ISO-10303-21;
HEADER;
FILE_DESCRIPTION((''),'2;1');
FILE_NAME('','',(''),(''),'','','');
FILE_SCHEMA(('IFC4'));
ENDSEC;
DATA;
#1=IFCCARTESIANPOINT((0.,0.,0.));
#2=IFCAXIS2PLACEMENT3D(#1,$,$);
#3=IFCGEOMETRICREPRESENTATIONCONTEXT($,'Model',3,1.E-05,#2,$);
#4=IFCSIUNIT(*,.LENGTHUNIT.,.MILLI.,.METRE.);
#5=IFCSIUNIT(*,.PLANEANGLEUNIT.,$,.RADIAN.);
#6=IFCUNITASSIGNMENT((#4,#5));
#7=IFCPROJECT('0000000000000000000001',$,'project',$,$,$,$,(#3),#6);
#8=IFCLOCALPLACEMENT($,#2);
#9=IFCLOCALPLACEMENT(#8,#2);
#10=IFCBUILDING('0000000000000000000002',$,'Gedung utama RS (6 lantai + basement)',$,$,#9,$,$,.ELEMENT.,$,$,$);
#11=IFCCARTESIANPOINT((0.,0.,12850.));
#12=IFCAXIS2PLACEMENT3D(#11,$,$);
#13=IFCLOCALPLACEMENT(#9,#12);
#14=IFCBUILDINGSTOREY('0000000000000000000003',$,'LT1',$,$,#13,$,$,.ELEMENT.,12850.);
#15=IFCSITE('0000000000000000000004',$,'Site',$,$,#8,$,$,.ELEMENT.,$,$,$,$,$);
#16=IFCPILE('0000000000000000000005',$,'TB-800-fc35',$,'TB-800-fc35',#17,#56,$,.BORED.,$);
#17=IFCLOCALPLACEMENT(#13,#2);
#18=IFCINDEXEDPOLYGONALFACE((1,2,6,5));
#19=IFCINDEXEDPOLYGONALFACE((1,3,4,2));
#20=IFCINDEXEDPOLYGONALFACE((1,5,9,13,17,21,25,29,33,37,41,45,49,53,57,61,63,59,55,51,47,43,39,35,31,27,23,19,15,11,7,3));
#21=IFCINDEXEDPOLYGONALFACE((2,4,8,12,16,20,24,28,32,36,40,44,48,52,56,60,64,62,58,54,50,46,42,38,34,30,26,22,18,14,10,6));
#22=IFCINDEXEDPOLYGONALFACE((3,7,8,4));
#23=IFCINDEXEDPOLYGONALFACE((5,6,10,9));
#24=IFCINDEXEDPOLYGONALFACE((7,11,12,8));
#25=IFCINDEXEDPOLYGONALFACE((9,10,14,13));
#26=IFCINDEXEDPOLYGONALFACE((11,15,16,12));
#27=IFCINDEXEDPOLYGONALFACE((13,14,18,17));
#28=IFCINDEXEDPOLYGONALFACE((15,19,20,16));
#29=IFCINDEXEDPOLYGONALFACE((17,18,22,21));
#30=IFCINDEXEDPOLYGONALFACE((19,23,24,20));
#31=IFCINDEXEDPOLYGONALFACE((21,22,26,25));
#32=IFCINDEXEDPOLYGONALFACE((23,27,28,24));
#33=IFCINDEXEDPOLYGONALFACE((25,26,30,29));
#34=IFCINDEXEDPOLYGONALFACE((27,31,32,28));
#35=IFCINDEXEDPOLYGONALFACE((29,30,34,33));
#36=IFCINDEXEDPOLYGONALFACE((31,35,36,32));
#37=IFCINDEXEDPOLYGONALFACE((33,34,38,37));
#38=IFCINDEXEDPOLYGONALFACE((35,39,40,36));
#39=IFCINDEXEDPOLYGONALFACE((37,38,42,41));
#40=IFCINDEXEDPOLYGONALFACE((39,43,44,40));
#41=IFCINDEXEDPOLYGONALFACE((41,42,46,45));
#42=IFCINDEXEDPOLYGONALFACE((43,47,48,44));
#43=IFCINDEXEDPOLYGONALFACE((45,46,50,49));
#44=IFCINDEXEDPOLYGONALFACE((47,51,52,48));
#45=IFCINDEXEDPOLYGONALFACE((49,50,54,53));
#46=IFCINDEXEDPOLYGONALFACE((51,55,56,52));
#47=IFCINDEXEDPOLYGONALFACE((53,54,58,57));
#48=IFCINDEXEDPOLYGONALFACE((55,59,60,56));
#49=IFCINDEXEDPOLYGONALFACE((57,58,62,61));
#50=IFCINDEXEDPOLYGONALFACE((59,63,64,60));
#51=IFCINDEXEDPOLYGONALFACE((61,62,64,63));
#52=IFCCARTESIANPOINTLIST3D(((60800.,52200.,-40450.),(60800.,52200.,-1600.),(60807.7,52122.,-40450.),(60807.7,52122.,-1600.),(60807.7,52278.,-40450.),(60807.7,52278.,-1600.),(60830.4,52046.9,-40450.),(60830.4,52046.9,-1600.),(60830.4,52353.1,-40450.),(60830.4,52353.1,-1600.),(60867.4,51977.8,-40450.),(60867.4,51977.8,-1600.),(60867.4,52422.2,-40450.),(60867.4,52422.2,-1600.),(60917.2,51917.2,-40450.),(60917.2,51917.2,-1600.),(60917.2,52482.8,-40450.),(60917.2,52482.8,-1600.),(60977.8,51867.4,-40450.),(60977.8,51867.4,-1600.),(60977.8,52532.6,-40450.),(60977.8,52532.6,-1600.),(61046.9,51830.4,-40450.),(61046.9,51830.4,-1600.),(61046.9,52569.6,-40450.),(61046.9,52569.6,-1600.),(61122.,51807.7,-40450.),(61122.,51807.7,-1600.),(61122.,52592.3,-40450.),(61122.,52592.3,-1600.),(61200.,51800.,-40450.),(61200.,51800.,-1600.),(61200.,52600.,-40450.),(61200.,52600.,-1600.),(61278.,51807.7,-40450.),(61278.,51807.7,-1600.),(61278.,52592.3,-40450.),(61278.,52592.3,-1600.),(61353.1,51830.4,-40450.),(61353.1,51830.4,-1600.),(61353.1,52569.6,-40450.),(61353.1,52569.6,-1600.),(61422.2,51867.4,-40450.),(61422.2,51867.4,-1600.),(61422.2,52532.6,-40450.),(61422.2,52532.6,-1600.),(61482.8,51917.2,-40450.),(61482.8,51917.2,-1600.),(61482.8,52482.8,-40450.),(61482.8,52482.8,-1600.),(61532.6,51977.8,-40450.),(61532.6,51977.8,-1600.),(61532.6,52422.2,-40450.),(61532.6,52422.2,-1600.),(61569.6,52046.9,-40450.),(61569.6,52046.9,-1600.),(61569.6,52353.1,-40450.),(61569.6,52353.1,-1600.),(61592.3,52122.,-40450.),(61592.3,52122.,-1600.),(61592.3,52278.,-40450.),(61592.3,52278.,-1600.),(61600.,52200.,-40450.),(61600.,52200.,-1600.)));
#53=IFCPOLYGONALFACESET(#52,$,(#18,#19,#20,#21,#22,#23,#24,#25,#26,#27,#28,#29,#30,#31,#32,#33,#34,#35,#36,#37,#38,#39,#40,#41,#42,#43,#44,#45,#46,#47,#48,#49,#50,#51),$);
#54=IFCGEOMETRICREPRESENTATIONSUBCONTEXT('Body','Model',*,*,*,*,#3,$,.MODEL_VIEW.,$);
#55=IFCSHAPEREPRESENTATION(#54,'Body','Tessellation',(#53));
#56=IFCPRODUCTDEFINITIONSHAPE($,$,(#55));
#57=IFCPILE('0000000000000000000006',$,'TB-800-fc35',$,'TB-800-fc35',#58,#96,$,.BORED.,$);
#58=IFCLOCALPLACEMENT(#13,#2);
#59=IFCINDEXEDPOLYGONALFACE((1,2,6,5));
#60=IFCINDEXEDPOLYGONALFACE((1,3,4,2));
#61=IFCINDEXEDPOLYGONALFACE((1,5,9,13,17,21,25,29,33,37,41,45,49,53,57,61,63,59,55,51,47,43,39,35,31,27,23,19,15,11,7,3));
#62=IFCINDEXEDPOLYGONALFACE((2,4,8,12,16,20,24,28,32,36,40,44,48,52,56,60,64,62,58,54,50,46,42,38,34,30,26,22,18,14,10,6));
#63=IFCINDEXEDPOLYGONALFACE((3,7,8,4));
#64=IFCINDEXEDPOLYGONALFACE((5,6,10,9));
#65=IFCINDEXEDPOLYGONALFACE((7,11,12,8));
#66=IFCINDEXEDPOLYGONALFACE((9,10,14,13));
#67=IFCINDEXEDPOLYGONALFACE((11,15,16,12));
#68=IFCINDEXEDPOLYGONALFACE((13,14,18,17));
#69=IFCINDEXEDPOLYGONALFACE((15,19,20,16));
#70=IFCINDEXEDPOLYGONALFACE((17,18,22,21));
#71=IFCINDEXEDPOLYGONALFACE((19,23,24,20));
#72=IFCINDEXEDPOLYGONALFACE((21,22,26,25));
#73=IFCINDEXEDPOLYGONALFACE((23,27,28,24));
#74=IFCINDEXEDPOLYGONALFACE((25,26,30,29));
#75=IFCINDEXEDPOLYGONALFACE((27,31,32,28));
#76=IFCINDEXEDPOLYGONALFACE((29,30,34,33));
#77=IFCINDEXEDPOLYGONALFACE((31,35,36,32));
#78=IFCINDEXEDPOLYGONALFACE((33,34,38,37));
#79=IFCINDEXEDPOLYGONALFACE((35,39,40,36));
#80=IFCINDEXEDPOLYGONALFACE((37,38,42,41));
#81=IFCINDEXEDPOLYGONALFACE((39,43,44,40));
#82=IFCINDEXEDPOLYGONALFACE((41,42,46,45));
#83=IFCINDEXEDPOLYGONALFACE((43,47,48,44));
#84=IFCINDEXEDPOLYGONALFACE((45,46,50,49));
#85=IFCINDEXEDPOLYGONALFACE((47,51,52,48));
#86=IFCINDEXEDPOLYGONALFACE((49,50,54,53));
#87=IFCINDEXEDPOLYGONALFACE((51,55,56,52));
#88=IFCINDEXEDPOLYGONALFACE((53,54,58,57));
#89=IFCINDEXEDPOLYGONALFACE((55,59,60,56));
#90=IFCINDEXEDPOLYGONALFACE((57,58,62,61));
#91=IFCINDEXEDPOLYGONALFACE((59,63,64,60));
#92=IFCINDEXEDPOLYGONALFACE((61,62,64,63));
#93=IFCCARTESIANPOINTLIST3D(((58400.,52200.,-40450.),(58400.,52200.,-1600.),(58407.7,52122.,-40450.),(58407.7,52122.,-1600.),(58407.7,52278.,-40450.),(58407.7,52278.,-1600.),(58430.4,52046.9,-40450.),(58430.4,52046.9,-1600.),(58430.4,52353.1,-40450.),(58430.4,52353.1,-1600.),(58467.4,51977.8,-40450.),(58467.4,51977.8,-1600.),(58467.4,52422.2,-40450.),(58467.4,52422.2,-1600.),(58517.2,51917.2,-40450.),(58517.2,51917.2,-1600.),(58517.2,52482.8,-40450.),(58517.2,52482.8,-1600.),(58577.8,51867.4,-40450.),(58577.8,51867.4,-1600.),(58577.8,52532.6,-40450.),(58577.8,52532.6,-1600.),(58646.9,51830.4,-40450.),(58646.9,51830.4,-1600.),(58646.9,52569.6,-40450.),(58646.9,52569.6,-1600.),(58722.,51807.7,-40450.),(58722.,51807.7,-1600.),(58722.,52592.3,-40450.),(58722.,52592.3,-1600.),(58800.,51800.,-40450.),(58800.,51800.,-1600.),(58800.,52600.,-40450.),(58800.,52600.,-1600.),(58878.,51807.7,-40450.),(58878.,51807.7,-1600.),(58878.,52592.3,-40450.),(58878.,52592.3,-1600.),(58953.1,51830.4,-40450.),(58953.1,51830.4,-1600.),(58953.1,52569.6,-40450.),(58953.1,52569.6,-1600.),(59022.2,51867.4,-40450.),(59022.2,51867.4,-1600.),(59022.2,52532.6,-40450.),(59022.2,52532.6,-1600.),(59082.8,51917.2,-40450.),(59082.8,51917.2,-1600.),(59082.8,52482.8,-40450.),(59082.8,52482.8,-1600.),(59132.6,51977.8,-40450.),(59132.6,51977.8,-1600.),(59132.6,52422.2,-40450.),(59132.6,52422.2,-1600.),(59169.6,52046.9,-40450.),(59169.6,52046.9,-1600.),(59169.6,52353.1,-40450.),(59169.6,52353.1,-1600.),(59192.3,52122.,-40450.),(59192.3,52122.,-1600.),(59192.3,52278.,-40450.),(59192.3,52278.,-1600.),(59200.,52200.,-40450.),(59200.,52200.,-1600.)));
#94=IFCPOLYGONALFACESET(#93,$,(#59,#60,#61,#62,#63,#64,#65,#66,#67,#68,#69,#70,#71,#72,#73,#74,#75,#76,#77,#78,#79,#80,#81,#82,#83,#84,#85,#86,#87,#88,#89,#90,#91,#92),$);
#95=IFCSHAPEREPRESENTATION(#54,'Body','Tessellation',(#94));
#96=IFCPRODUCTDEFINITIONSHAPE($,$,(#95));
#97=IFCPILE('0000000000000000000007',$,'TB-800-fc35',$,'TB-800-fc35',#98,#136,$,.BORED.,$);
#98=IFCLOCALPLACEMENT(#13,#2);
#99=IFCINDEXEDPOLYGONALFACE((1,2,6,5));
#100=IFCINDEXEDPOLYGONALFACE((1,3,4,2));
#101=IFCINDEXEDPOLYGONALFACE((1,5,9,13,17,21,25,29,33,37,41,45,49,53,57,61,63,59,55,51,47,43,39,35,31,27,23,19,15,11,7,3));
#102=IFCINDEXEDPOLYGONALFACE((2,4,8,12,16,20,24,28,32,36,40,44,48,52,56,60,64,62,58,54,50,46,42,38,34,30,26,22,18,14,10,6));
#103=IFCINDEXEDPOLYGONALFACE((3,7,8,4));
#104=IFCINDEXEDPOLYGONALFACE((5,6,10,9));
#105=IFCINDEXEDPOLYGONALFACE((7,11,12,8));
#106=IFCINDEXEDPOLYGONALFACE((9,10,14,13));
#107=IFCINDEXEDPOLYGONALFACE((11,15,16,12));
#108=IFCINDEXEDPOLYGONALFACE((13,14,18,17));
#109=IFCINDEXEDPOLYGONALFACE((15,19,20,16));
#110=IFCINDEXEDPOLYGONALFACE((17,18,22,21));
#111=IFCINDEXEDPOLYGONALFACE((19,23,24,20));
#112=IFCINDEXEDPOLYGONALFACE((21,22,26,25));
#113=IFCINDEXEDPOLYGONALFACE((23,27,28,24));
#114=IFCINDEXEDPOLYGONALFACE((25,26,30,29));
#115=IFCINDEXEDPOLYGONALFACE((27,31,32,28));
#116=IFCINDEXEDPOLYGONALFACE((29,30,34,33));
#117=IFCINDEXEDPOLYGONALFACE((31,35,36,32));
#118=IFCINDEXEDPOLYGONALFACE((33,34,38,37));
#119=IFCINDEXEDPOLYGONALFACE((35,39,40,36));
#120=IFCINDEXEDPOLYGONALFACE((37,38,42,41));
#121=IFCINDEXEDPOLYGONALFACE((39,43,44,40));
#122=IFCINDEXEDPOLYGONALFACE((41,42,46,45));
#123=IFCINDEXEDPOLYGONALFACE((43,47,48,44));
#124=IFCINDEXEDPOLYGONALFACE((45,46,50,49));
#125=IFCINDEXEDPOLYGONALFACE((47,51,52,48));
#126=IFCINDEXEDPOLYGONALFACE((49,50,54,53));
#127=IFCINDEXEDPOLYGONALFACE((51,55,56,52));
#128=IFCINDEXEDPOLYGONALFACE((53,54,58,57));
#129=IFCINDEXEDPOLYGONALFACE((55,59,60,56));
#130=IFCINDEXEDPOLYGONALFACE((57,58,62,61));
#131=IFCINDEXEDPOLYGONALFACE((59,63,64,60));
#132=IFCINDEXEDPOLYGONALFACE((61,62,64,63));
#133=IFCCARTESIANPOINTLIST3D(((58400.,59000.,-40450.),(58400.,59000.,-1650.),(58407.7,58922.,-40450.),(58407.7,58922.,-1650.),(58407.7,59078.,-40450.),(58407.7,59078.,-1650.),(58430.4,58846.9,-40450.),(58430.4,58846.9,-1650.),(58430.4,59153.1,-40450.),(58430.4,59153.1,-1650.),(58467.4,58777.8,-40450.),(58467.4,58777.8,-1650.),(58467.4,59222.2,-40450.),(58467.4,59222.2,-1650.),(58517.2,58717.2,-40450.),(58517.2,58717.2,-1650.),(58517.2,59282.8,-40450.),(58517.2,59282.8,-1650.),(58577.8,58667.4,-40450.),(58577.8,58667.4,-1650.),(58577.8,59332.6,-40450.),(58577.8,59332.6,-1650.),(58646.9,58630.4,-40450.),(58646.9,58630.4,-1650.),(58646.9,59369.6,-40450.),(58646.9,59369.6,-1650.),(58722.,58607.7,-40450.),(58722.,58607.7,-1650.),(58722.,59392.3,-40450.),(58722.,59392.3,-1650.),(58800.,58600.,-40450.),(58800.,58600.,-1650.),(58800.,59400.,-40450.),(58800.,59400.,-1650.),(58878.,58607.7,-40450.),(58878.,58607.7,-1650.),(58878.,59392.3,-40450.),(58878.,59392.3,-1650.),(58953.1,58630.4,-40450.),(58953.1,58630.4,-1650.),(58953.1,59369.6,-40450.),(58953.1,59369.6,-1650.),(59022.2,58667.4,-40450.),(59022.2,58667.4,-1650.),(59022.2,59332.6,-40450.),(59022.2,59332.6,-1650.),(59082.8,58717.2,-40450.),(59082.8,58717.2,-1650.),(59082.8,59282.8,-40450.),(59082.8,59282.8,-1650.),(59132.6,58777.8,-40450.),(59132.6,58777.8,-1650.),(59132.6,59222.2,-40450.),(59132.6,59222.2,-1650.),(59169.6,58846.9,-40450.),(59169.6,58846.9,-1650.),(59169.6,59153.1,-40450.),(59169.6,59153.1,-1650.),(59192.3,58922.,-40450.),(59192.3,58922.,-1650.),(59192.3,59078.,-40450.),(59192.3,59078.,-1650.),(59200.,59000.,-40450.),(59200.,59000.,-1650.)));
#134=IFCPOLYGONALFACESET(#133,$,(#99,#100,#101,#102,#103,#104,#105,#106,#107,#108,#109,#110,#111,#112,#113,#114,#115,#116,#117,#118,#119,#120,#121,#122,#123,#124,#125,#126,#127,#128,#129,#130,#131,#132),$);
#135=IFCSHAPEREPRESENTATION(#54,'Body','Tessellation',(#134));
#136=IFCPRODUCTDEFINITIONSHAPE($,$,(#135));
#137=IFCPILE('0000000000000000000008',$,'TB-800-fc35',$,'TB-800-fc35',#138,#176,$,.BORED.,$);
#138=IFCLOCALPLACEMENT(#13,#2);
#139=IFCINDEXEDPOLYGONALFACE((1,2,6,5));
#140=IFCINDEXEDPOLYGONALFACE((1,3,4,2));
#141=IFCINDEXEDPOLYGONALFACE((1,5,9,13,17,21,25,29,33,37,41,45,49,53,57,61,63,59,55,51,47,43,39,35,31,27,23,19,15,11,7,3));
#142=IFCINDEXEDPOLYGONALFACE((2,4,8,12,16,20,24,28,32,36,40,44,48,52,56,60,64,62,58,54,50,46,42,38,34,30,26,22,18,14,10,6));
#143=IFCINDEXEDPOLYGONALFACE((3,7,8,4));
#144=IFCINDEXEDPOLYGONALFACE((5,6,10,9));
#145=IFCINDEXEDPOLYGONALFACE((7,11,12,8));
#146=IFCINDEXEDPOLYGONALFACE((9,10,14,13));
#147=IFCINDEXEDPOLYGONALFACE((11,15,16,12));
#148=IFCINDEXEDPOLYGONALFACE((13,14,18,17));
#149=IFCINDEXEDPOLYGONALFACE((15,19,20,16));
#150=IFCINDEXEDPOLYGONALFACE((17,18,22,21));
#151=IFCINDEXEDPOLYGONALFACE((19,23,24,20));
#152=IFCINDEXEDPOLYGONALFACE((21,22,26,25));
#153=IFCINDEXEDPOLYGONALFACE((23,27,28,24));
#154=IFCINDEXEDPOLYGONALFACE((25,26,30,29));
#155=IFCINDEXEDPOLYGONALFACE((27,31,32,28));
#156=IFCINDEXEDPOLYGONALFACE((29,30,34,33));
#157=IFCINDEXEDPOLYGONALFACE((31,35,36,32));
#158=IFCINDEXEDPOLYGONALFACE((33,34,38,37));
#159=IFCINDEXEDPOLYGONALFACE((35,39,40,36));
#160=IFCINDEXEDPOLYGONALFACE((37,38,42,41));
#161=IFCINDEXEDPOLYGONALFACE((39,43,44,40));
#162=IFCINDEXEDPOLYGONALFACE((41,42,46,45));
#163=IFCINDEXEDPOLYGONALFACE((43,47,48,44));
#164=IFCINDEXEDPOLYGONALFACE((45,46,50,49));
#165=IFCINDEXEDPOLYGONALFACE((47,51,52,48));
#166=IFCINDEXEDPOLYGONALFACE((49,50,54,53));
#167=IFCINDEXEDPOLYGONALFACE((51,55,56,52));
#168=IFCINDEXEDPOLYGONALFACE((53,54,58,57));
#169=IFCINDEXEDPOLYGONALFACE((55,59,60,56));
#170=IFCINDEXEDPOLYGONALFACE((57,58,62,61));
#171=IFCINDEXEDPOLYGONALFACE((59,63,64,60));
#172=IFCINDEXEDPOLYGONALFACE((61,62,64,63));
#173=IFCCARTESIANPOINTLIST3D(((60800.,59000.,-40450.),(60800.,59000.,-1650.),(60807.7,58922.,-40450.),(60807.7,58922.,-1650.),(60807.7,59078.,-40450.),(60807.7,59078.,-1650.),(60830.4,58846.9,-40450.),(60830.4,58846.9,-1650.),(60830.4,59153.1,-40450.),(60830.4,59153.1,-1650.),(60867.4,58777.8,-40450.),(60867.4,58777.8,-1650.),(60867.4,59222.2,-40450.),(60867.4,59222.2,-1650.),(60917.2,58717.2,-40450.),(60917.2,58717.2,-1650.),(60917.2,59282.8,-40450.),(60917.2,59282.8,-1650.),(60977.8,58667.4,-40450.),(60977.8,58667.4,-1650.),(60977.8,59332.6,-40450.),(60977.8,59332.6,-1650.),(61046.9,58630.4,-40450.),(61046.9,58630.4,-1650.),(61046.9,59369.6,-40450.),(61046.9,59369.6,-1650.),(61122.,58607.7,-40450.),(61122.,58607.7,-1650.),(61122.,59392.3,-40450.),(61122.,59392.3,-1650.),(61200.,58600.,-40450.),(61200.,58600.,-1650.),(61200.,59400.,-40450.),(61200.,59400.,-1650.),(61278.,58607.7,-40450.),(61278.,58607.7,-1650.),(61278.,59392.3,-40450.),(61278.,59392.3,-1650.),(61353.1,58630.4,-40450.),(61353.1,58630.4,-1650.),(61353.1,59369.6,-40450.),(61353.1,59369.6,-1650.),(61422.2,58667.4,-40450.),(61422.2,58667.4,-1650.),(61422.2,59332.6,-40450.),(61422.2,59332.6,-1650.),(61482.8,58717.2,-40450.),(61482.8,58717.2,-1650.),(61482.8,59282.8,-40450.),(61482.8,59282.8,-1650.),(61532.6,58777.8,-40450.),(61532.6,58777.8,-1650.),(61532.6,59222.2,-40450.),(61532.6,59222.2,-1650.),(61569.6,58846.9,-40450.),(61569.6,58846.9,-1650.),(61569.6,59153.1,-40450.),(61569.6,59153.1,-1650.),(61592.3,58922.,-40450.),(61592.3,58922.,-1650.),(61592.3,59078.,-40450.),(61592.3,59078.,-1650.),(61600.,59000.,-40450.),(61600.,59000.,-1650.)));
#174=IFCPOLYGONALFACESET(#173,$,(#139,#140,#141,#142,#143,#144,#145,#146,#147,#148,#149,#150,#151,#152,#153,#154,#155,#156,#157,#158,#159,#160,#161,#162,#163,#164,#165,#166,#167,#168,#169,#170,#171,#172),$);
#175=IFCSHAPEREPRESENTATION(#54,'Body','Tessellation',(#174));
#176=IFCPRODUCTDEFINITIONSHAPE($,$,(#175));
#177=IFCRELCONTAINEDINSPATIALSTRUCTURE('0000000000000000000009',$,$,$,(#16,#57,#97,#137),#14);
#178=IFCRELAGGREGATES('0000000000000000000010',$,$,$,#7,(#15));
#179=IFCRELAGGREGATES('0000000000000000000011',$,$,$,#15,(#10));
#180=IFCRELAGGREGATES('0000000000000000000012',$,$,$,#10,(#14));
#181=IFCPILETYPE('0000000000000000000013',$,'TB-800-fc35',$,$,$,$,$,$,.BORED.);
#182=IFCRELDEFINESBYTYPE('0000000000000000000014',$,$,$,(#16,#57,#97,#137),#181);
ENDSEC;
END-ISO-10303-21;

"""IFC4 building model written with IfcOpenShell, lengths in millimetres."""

from ifc_helpers import new_model, si_unit, frame, origin, origin_2d, place, context, subcontext, project, spatial, circle, extrude, material_profile, profile_set, profile_usage, type_object, element, save


model = new_model("IFC4")

# Units and contexts
model_context = context("Model", 3, precision=1e-05, world=origin())
body_context = subcontext(model_context, "Body", "Model", "MODEL_VIEW")
ifc_project = project(units=[si_unit("LENGTHUNIT", "METRE", prefix="MILLI"), si_unit("PLANEANGLEUNIT", "RADIAN")], contexts=[model_context])

# Site, building, storey
site_placement = place(None, origin())
site = spatial("IfcSite", under=ifc_project, at=site_placement, Name="Site", CompositionType="ELEMENT")
building_placement = place(site_placement, origin())
building = spatial("IfcBuilding", under=site, at=building_placement, Name="Gedung utama RS (6 lantai + basement)", CompositionType="ELEMENT")
storey_placement = place(building_placement, frame((0.0, 0.0, 12850.0)))
storey = spatial("IfcBuildingStorey", under=building, at=storey_placement, Name="LT1", CompositionType="ELEMENT", Elevation=12850.0)

# Piles
ifc_material_profile = material_profile(None, circle(Radius=400.0, at=origin_2d()), Name="TB-800-fc35")
ifc_profile_set = profile_set([ifc_material_profile], Name="TB-800-fc35")
ifc_profile_usage = profile_usage(ifc_profile_set, cardinal=5)
pile_type = type_object("IfcPileType", Name="TB-800-fc35", PredefinedType="BORED")
for number, where, z_axis, x_axis, name in (
    (1, (61200.0, 52200.0, -40450.0), (0.0, 0.0, 1.0), (1.0, 0.0, 0.0), "TB-800-fc35"),
    (2, (58800.0, 52200.0, -40450.0), (0.0, 0.0, 1.0), (1.0, 0.0, 0.0), "TB-800-fc35"),
):
    element("IfcPile", number, at=place(storey_placement, frame(where, z_axis=z_axis, x_axis=x_axis)), inside=storey, type_object=pile_type, material=ifc_profile_usage, Name=name, ObjectType="TB-800-fc35", PredefinedType="BORED", context=body_context, shape_type="SweptSolid", body=[
        extrude(circle(Radius=400.0, at=origin_2d()), origin(), (0.0, 0.0, 1.0), 38850.0),
    ])
for number, where, z_axis, x_axis, name in (
    (3, (58800.0, 59000.0, -40450.0), (0.0, 0.0, 1.0), (1.0, 0.0, 0.0), "TB-800-fc35"),
    (4, (61200.0, 59000.0, -40450.0), (0.0, 0.0, 1.0), (1.0, 0.0, 0.0), "TB-800-fc35"),
):
    element("IfcPile", number, at=place(storey_placement, frame(where, z_axis=z_axis, x_axis=x_axis)), inside=storey, type_object=pile_type, material=ifc_profile_usage, Name=name, ObjectType="TB-800-fc35", PredefinedType="BORED", context=body_context, shape_type="SweptSolid", body=[
        extrude(circle(Radius=400.0, at=origin_2d()), origin(), (0.0, 0.0, 1.0), 38800.0),
    ])

save(model, "model.ifc")
